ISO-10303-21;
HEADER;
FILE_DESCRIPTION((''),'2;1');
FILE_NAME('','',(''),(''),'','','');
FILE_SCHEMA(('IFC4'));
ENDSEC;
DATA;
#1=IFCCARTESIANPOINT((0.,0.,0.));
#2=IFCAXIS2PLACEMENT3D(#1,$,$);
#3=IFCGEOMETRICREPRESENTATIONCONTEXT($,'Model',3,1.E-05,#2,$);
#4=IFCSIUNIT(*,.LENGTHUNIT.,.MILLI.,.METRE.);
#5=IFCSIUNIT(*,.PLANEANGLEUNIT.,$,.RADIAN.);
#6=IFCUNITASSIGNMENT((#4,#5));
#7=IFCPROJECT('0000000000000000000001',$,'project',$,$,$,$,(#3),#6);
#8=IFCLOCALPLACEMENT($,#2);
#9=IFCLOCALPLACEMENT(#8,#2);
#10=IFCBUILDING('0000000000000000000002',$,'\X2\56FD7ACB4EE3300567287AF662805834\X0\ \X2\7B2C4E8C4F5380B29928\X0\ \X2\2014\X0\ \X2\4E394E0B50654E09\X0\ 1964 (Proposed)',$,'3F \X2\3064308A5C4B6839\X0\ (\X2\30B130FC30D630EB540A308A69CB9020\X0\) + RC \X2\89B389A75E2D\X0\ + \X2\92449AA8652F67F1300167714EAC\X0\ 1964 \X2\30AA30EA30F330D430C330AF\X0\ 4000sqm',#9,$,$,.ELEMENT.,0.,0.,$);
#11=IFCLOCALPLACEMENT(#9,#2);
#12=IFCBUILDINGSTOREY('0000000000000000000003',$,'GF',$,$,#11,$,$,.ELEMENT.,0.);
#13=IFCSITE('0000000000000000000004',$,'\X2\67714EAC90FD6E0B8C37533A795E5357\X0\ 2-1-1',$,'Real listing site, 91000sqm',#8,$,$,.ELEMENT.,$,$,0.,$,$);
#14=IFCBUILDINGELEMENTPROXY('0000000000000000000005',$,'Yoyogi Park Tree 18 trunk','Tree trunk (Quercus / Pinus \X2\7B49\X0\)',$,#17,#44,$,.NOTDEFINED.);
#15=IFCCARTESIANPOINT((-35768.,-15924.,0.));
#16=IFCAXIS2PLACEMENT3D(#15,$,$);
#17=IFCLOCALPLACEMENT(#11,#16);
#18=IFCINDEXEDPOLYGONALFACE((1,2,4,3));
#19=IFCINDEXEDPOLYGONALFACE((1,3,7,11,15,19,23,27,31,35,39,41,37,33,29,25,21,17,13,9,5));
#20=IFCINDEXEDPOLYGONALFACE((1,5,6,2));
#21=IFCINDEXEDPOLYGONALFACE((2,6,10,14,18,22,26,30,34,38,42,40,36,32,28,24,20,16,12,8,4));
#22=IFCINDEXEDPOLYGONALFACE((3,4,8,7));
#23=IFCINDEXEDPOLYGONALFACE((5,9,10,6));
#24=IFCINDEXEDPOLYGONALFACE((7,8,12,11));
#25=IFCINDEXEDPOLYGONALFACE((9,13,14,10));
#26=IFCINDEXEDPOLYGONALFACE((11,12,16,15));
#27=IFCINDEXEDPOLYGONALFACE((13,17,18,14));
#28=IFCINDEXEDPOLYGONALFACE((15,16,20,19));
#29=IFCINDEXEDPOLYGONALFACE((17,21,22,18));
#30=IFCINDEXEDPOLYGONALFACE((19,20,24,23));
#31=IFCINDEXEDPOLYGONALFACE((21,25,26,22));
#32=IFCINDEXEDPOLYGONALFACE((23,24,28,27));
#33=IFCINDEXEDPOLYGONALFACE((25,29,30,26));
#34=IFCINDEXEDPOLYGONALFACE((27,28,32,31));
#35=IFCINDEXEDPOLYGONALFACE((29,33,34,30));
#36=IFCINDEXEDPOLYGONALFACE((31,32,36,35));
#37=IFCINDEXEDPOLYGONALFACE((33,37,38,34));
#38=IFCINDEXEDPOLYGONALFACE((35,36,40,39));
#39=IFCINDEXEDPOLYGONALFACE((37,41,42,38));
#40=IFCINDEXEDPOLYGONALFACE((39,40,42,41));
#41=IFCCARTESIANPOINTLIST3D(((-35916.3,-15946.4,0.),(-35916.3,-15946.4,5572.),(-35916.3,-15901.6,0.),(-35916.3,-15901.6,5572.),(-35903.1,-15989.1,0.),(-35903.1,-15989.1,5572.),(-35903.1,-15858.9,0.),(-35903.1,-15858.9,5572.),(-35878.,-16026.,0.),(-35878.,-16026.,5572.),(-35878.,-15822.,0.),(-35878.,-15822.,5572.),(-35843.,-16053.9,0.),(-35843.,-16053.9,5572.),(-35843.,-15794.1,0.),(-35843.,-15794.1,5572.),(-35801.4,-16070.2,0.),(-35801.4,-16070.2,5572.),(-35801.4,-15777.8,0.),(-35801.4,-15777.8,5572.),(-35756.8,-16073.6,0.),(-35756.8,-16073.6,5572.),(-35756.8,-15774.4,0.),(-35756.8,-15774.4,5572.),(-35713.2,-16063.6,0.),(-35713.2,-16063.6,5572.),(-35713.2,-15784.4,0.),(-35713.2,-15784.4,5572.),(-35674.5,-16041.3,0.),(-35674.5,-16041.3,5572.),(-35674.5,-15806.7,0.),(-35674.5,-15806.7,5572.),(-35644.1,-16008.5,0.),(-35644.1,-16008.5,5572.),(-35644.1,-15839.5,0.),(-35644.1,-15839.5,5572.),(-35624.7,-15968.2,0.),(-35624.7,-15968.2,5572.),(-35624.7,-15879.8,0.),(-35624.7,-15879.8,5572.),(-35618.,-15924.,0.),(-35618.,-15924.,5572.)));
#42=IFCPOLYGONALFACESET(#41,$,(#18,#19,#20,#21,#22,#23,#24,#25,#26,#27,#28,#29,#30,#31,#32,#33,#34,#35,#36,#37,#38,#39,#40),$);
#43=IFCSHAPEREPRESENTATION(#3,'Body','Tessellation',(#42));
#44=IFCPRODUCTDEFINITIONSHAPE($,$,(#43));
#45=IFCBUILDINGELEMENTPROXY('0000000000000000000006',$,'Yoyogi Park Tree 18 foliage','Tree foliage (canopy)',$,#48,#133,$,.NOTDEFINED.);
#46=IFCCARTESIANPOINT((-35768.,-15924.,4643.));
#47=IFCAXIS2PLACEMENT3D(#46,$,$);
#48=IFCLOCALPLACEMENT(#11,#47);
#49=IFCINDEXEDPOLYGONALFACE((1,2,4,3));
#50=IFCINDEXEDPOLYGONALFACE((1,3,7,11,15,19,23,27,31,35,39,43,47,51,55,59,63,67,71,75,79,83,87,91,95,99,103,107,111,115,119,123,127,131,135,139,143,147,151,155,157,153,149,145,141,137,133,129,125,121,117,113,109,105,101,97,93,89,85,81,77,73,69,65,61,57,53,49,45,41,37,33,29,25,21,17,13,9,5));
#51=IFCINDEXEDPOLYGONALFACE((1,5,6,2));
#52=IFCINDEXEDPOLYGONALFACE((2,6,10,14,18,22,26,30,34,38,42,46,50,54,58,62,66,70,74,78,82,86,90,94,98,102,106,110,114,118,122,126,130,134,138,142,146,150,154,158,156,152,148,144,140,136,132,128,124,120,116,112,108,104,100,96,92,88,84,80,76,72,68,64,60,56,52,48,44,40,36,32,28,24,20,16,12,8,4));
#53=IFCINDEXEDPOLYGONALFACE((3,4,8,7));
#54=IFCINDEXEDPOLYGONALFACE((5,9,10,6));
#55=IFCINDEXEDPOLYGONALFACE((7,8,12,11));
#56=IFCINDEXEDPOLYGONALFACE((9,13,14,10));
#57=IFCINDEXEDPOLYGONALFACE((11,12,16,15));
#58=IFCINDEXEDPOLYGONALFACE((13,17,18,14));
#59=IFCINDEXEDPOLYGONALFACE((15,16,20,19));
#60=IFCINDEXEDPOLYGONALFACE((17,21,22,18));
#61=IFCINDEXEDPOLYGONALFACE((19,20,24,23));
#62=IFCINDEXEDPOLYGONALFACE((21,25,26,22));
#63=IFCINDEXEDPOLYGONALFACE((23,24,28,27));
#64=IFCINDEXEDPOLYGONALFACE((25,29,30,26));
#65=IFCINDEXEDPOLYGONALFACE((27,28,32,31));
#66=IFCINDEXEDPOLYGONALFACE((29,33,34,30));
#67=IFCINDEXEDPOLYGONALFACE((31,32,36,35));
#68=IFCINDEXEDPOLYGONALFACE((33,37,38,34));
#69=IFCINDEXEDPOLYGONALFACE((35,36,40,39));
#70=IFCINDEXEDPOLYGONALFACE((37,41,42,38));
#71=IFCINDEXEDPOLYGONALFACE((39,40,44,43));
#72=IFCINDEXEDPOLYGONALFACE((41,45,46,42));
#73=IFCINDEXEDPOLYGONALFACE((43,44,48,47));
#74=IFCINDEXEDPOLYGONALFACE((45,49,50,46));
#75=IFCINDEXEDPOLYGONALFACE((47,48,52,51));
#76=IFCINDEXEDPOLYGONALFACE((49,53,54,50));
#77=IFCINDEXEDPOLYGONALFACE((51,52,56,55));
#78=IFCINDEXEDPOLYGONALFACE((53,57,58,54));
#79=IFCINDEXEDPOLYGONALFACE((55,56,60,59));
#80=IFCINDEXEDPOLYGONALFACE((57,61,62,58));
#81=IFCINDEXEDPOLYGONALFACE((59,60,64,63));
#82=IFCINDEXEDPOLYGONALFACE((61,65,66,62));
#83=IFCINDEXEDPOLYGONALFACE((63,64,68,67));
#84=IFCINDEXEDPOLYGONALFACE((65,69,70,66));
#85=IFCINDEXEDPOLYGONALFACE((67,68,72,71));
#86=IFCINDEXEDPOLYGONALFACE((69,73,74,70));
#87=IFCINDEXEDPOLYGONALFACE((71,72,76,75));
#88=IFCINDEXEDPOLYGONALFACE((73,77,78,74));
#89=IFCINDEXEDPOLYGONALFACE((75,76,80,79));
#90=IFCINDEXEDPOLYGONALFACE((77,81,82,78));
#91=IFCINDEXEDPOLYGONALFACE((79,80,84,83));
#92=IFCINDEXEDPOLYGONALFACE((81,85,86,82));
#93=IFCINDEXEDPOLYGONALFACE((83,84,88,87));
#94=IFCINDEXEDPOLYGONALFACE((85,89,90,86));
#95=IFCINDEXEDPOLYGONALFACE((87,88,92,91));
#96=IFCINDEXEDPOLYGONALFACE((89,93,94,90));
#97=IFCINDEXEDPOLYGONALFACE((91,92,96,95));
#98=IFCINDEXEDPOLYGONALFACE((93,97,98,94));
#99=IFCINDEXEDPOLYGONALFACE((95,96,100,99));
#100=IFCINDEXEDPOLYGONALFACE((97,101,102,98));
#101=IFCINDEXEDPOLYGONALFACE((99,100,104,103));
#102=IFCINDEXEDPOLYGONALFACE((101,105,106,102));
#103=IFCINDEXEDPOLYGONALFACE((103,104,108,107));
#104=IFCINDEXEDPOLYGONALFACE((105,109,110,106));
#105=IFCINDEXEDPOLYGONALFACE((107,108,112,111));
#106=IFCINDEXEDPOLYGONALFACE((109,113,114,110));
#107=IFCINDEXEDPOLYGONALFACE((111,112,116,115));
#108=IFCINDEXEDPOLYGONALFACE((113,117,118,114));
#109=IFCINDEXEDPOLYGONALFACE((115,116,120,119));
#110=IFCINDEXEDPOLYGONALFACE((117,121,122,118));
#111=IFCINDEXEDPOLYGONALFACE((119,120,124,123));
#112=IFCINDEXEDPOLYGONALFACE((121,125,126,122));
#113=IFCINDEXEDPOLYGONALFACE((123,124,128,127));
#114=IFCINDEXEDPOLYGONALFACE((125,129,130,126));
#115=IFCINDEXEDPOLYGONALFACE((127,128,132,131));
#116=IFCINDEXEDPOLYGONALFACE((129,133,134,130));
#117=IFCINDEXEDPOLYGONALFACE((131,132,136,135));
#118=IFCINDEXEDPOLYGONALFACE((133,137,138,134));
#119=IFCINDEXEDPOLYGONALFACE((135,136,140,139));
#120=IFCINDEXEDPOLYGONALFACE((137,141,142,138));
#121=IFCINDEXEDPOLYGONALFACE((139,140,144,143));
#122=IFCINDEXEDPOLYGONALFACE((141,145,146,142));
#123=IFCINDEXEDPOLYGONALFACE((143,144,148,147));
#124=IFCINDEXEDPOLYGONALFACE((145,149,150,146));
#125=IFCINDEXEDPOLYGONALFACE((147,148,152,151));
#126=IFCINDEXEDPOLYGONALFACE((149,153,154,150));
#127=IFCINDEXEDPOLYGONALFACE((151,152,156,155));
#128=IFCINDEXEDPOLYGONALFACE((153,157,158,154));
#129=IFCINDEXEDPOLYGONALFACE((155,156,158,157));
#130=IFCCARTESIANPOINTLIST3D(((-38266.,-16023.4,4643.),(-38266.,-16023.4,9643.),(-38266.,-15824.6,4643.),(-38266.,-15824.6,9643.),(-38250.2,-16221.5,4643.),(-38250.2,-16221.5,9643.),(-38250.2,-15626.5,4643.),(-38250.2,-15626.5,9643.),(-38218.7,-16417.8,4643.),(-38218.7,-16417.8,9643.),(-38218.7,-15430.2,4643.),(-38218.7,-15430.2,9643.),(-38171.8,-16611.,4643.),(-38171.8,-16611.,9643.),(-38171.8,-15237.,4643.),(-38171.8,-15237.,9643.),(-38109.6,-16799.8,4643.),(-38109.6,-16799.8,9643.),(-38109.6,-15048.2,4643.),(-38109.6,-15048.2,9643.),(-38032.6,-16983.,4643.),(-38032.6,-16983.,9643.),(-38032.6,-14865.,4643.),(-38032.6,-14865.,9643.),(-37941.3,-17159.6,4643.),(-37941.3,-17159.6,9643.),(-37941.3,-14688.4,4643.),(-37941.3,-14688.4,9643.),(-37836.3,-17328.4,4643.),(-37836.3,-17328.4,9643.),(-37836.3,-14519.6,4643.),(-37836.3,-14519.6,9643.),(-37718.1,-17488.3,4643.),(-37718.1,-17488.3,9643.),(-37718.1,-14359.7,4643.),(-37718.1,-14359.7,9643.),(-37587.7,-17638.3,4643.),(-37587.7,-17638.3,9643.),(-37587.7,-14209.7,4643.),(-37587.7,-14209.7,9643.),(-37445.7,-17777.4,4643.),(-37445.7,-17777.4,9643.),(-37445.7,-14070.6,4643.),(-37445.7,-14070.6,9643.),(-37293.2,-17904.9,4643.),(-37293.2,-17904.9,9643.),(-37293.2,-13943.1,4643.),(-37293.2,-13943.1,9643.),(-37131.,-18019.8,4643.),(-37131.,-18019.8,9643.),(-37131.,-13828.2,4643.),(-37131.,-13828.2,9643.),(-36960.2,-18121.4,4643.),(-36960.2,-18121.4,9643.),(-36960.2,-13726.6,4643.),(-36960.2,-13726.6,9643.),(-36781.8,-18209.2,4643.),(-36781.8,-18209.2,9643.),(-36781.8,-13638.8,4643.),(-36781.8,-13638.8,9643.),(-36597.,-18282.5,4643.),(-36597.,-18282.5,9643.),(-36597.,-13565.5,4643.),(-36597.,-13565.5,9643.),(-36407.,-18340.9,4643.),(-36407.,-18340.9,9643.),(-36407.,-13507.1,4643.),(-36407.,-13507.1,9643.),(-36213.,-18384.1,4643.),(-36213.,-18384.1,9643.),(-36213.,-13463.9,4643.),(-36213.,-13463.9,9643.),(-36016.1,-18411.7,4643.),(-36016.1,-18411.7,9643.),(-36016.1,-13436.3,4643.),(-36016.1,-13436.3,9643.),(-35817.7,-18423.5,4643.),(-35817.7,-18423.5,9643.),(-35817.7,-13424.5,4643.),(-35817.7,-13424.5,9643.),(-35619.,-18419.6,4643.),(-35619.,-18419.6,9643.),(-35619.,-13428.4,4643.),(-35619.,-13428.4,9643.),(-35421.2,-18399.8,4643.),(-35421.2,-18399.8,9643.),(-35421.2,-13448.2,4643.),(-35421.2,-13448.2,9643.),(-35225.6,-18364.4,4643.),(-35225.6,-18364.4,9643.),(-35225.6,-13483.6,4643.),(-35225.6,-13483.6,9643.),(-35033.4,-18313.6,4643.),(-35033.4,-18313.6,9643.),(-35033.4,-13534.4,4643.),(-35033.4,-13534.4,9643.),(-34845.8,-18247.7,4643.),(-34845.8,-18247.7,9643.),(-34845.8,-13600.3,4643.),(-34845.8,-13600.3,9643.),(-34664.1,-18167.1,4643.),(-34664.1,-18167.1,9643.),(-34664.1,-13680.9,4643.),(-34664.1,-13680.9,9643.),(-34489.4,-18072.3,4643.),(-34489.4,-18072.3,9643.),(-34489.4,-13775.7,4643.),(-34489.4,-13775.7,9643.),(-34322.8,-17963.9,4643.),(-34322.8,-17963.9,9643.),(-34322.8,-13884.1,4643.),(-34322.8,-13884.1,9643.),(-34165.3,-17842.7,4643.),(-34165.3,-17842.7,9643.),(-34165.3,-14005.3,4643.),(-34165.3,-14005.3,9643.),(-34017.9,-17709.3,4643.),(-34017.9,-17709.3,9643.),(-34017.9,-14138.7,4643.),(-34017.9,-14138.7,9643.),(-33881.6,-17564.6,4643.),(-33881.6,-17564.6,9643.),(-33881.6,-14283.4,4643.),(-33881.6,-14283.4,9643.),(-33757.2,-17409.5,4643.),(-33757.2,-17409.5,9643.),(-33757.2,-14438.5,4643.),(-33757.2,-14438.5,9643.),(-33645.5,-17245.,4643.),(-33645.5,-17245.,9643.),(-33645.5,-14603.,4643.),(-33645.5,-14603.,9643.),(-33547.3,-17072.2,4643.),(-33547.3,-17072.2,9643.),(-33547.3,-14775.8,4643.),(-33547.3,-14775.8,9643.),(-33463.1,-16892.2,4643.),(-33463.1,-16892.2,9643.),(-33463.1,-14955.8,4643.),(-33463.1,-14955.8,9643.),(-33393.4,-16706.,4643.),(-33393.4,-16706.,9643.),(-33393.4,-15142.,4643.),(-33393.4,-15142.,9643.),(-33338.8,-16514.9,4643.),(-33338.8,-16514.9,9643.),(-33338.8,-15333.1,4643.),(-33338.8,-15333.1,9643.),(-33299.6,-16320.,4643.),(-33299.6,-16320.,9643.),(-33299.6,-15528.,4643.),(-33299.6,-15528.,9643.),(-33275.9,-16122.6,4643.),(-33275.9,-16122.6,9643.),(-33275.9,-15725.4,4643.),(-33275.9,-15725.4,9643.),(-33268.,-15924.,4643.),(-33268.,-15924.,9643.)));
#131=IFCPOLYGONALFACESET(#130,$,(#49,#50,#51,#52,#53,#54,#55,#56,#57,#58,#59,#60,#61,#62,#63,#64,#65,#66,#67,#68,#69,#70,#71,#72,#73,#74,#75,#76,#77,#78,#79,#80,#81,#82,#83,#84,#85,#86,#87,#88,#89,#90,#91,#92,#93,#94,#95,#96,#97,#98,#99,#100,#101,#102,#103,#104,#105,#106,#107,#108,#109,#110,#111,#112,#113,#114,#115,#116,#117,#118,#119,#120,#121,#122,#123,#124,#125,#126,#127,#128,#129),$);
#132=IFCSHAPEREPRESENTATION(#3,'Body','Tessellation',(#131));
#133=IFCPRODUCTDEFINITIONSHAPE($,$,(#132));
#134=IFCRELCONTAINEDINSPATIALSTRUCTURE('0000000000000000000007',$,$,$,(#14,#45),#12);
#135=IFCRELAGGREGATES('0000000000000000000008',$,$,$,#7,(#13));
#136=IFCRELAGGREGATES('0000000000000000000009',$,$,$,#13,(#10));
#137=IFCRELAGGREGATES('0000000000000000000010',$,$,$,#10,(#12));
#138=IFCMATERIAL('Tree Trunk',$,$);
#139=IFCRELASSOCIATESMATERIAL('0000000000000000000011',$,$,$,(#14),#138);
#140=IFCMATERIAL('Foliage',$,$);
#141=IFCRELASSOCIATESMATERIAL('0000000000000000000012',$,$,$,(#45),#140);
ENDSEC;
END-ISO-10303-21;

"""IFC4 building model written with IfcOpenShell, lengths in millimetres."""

from ifc_helpers import new_model, si_unit, frame, origin, origin_2d, place, context, project, spatial, circle, extrude, material, element, save


model = new_model("IFC4")

# Units and contexts
model_context = context("Model", 3, precision=1e-05, world=origin())
ifc_project = project(units=[si_unit("LENGTHUNIT", "METRE", prefix="MILLI"), si_unit("PLANEANGLEUNIT", "RADIAN")], contexts=[model_context])

# Site, building, storey
site_placement = place(None, origin())
site = spatial("IfcSite", under=ifc_project, at=site_placement, Name="東京都渋谷区神南 2-1-1", ObjectType="Real listing site, 91000sqm", CompositionType="ELEMENT", RefElevation=0.0)
building_placement = place(site_placement, origin())
building = spatial("IfcBuilding", under=site, at=building_placement, Name="国立代々木競技場 第二体育館 — 丹下健三 1964 (Proposed)", ObjectType="3F つり屋根 (ケーブル吊り構造) + RC 観覧席 + 鉄骨支柱、東京 1964 オリンピック 4000sqm", CompositionType="ELEMENT", ElevationOfRefHeight=0.0, ElevationOfTerrain=0.0)
storey_placement = place(building_placement, origin())
storey = spatial("IfcBuildingStorey", under=building, at=storey_placement, Name="GF", CompositionType="ELEMENT", Elevation=0.0)

# Building element proxies
ifc_material_1 = material(Name="Tree Trunk")
ifc_material_2 = material(Name="Foliage")
proxy_1_placement = place(storey_placement, frame((-35768.0, -15924.0, 0.0)))
element("IfcBuildingElementProxy", 1, at=proxy_1_placement, inside=storey, material=ifc_material_1, Name="Yoyogi Park Tree 18 trunk", Description="Tree trunk (Quercus / Pinus 等)", PredefinedType="NOTDEFINED", context=model_context, shape_type="SweptSolid", body=[
    extrude(circle(Radius=150.0, at=origin_2d()), frame((-35768.0, -15924.0, 0.0)), (0.0, 0.0, 1.0), 5572.0),
])
proxy_2_placement = place(storey_placement, frame((-35768.0, -15924.0, 4643.0)))
element("IfcBuildingElementProxy", 2, at=proxy_2_placement, inside=storey, material=ifc_material_2, Name="Yoyogi Park Tree 18 foliage", Description="Tree foliage (canopy)", PredefinedType="NOTDEFINED", context=model_context, shape_type="SweptSolid", body=[
    extrude(circle(Radius=2500.0, at=origin_2d()), frame((-35768.0, -15924.0, 4643.0)), (0.0, 0.0, 1.0), 5000.0),
])

save(model, "model.ifc")
